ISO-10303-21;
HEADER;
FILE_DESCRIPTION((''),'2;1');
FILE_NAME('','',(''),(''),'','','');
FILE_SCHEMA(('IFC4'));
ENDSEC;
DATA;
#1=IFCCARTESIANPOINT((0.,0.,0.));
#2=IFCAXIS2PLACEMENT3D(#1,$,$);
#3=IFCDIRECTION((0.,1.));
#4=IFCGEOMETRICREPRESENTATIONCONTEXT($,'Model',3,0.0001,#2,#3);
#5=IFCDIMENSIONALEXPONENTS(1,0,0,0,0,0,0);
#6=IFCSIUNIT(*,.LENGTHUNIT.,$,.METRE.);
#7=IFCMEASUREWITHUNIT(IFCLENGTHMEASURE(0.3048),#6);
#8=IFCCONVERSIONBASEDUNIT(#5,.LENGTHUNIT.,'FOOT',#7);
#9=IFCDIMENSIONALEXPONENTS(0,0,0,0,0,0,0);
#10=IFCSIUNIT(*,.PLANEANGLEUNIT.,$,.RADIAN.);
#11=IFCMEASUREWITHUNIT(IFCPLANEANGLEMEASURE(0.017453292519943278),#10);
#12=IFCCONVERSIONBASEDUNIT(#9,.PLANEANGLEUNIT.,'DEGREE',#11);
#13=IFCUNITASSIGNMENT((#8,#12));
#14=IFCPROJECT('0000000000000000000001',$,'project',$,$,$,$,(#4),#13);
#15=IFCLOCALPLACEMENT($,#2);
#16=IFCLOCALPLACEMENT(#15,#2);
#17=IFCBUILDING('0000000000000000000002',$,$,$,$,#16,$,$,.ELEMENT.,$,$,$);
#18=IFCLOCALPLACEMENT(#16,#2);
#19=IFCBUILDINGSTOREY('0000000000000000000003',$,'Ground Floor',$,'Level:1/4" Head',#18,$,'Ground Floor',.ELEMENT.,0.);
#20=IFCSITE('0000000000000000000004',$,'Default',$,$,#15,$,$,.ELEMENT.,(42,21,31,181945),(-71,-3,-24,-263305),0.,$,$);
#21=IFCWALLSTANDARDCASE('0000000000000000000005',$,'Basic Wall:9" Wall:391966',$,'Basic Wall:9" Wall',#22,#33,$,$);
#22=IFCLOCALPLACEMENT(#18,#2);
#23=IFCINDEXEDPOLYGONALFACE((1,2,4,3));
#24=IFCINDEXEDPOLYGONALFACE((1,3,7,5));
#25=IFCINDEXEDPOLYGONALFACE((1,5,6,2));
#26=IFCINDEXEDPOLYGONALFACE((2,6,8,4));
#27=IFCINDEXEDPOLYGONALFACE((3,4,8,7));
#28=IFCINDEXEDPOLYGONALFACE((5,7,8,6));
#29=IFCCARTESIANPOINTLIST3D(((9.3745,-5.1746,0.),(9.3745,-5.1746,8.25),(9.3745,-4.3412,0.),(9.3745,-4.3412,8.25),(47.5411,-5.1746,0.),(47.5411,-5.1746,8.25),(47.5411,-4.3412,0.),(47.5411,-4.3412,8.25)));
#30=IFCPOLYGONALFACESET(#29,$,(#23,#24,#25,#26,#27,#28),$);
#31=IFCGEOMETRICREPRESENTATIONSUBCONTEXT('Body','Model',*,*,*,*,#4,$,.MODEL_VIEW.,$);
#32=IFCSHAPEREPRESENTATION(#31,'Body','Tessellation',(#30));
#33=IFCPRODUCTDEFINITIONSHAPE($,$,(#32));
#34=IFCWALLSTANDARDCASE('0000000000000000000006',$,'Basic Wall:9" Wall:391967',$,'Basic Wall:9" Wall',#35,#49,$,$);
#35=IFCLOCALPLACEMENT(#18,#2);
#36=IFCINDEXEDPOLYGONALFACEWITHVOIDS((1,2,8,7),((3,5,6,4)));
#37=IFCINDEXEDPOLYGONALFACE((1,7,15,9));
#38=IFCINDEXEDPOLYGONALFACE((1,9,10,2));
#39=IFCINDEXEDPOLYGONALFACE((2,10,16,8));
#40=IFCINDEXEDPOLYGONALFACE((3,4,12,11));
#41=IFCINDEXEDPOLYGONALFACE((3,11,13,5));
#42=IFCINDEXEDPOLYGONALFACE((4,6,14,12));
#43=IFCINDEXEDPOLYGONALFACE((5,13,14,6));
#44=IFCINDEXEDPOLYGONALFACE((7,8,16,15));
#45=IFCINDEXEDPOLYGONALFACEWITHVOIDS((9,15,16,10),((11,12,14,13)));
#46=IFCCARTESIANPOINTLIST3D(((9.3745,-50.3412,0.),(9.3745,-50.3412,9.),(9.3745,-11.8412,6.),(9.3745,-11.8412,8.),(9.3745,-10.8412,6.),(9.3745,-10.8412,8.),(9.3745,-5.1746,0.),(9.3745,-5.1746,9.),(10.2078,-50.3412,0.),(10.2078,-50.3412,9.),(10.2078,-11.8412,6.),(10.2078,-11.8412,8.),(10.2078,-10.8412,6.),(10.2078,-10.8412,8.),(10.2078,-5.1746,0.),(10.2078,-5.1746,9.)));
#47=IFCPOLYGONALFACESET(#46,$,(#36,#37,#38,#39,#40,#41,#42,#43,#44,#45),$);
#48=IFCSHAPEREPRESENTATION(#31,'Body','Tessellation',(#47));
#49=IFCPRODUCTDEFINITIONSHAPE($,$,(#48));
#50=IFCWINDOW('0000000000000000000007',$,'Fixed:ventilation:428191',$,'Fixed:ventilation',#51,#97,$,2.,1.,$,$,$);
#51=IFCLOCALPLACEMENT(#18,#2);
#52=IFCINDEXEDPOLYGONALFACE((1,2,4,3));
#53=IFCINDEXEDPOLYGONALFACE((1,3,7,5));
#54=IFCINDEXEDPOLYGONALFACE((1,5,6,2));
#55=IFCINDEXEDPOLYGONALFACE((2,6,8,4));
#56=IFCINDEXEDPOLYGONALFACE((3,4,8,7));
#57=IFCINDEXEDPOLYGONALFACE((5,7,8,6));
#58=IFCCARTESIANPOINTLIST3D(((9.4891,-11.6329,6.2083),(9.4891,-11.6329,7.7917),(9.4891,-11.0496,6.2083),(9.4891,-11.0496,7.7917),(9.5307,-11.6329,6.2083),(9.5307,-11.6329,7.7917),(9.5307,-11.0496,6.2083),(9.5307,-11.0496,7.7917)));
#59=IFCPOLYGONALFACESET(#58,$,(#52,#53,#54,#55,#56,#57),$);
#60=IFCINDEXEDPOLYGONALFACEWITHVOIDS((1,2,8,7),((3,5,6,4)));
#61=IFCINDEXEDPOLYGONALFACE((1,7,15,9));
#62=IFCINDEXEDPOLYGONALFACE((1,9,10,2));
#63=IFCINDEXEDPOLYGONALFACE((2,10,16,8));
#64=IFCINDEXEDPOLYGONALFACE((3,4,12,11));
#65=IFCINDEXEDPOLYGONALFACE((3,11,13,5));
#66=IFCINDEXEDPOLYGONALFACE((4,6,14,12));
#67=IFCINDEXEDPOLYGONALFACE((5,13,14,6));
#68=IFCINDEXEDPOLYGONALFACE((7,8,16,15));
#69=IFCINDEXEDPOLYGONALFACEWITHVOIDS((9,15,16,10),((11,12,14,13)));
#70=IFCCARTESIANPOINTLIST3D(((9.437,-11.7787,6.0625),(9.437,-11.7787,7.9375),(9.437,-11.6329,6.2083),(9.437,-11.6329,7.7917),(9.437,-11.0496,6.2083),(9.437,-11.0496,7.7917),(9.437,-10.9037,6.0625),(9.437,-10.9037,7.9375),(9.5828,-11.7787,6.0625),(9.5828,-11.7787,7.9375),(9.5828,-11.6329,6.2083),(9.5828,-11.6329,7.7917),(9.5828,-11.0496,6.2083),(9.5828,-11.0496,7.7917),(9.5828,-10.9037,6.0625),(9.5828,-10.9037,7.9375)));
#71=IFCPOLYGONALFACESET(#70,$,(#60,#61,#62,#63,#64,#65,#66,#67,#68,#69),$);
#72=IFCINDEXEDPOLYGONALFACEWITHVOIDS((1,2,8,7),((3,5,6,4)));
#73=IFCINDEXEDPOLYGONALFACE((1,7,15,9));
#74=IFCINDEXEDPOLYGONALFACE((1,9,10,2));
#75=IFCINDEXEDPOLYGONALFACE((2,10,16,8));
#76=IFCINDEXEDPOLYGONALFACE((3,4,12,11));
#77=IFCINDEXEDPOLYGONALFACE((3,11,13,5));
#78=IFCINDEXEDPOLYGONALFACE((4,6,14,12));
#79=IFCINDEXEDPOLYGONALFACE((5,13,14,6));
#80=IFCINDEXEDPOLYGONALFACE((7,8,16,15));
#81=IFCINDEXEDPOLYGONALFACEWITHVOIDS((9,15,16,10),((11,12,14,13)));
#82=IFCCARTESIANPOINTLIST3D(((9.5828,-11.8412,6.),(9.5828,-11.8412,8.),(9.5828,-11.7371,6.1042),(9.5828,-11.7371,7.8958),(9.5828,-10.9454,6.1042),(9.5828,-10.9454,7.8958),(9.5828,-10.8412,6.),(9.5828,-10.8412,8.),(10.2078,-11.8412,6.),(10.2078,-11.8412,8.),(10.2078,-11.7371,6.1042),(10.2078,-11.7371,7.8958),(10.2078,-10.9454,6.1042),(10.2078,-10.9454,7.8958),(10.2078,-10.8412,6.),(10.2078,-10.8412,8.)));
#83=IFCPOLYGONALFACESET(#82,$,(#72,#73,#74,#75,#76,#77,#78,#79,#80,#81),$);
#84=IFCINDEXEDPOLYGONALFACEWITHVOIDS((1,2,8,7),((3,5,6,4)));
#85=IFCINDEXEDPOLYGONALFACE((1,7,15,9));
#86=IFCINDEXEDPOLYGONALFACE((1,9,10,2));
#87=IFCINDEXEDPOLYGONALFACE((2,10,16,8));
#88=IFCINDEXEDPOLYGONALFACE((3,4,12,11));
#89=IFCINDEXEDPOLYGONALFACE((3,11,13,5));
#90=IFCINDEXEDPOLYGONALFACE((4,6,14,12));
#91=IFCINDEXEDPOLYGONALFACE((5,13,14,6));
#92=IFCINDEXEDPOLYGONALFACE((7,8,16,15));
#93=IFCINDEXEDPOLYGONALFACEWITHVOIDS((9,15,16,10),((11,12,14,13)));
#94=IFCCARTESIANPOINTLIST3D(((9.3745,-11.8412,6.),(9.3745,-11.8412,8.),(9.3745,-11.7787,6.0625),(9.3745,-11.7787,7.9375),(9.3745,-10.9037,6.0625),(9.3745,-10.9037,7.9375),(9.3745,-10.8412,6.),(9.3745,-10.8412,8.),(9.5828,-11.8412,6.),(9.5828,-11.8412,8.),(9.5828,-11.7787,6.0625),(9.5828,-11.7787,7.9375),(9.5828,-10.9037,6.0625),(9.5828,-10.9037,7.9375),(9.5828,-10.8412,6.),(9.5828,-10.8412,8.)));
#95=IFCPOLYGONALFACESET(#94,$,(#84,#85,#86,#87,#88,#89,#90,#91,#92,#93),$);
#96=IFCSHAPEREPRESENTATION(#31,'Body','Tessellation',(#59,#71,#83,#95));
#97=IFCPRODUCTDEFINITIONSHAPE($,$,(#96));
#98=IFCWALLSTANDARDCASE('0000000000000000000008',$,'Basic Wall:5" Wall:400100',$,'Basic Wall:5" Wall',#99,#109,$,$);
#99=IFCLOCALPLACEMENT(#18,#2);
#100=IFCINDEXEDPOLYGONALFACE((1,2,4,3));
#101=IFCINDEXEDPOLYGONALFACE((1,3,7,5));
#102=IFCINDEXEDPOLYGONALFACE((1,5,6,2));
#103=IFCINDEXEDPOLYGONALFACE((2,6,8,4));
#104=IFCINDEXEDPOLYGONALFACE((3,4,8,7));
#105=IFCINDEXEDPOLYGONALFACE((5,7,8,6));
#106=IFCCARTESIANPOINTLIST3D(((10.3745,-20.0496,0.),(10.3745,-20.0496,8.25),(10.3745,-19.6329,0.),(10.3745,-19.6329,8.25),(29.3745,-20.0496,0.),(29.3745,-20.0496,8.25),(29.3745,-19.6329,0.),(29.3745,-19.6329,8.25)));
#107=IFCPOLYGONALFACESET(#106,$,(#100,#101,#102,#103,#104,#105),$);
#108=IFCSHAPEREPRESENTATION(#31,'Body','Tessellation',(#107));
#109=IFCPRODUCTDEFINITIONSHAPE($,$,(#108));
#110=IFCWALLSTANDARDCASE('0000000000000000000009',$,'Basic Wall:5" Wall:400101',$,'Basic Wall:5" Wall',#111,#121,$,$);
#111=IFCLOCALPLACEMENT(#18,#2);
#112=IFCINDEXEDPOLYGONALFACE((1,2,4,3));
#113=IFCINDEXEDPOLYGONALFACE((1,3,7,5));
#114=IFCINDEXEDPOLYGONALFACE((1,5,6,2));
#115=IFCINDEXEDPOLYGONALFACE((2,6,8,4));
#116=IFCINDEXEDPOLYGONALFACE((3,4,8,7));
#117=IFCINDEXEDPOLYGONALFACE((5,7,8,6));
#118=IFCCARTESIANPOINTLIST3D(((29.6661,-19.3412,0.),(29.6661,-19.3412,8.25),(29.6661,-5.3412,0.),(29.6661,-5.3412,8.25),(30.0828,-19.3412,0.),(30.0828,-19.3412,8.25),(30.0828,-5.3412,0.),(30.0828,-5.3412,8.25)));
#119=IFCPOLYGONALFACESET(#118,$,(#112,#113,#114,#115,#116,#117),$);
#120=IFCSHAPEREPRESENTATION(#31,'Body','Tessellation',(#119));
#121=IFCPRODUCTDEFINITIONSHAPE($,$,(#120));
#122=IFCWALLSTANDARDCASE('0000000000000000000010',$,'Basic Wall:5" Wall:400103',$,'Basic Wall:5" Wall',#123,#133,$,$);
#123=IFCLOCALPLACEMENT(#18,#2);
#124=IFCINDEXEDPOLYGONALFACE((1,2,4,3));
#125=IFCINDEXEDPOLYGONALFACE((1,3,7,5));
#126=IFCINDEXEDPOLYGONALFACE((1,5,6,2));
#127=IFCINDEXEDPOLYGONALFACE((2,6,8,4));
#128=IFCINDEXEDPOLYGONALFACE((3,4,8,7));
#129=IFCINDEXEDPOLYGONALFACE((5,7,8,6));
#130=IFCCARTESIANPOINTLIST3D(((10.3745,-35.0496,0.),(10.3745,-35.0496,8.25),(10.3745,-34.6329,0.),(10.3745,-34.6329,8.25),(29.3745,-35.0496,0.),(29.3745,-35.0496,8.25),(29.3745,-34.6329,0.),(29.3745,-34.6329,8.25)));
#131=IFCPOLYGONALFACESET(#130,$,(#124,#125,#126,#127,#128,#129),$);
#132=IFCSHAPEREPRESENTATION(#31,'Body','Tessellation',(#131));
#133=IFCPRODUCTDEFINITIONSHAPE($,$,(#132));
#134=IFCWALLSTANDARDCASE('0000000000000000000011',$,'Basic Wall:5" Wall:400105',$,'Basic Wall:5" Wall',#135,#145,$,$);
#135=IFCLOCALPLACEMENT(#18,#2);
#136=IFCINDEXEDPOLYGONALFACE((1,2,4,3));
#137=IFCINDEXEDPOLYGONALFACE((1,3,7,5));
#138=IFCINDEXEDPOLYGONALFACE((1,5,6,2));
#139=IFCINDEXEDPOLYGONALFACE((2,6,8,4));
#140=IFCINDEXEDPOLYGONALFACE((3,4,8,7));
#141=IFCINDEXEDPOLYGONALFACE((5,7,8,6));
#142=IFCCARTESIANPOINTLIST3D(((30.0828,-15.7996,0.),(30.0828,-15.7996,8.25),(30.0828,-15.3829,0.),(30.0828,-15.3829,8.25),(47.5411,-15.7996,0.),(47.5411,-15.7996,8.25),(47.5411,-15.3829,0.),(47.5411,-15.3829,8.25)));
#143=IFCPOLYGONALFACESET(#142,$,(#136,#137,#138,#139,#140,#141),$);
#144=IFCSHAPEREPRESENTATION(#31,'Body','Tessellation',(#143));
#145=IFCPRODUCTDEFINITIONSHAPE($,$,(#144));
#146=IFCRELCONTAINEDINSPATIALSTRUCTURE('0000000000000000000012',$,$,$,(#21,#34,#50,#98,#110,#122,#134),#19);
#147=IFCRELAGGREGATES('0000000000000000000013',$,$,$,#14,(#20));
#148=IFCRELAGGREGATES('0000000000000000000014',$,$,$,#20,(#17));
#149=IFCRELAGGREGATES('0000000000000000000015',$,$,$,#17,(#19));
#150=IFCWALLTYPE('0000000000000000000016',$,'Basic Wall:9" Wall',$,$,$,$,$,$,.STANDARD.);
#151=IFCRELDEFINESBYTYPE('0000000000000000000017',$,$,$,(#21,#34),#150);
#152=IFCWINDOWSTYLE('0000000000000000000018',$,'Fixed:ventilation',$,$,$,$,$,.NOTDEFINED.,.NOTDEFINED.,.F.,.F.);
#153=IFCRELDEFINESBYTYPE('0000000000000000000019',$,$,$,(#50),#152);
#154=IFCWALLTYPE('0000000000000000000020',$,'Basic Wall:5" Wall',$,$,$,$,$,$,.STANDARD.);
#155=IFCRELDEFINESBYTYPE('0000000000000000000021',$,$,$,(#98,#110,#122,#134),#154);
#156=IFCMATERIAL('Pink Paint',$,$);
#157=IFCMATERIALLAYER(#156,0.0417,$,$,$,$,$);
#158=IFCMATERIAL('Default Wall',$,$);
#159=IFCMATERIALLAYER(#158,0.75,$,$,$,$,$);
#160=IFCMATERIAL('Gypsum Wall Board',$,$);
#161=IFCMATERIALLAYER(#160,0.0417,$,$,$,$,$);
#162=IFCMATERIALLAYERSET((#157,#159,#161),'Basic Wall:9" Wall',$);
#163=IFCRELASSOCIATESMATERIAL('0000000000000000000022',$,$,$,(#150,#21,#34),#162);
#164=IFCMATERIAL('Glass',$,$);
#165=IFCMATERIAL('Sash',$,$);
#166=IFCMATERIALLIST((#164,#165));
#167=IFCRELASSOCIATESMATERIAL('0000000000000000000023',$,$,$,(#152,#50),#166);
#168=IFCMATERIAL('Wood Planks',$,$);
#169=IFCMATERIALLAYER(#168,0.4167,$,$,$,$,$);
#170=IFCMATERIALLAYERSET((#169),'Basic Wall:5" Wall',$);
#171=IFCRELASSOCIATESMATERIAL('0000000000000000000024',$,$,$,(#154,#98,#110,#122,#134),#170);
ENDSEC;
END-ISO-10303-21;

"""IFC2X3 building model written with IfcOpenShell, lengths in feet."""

from ifc_helpers import new_model, entity, si_unit, converted_unit, direction, frame, frame_2d, origin, origin_2d_with_axis, place, context, subcontext, project, spatial, polyline, rectangle, outline, extrude, clip, bounded_halfspace, source, transform, mapped, material, material_list, layer, layer_set, layer_usage, type_object, type_shapes, element, fill, save


model = new_model("IFC2X3")

# Units and contexts
model_context = context("Model", 3, precision=0.0001, world=origin(), true_north=direction((0.0, 1.0)))
body_context = subcontext(model_context, "Body", "Model", "MODEL_VIEW")
ifc_project = project(units=[converted_unit("LENGTHUNIT", "FOOT", entity("IfcLengthMeasure", 0.3048), si_unit("LENGTHUNIT", "METRE"), dimensions=[1, 0, 0, 0, 0, 0, 0]), converted_unit("PLANEANGLEUNIT", "DEGREE", entity("IfcPlaneAngleMeasure", 0.017453292519943278), si_unit("PLANEANGLEUNIT", "RADIAN"), dimensions=[0, 0, 0, 0, 0, 0, 0])], contexts=[model_context])

# Site, building, storey
site_placement = place(None, origin())
site = spatial("IfcSite", under=ifc_project, at=site_placement, Name="Default", CompositionType="ELEMENT", RefLatitude=(42, 21, 31, 181945), RefLongitude=(-71, -3, -24, -263305), RefElevation=0.0)
building_placement = place(site_placement, origin())
building = spatial("IfcBuilding", under=site, at=building_placement, CompositionType="ELEMENT")
storey_placement = place(building_placement, origin())
storey = spatial("IfcBuildingStorey", under=building, at=storey_placement, Name="Ground Floor", ObjectType="Level:1/4\" Head", LongName="Ground Floor", CompositionType="ELEMENT", Elevation=0.0)

# Wall
ifc_material_1 = material(Name="Pink Paint")
ifc_layer_1 = layer(ifc_material_1, 0.0417)
ifc_material_2 = material(Name="Default Wall")
ifc_layer_2 = layer(ifc_material_2, 0.75)
ifc_material_3 = material(Name="Gypsum Wall Board")
ifc_layer_3 = layer(ifc_material_3, 0.0417)
ifc_layer_set_1 = layer_set([ifc_layer_1, ifc_layer_2, ifc_layer_3], Name="Basic Wall:9\" Wall")
ifc_layer_usage_1 = layer_usage(ifc_layer_set_1, "AXIS2", "NEGATIVE", 0.4167)
wall_type_1 = type_object("IfcWallType", Name="Basic Wall:9\" Wall", PredefinedType="STANDARD", material=ifc_layer_set_1)
wall_1_placement = place(storey_placement, frame((9.3745, -4.7579, 0.0)))
element("IfcWallStandardCase", 1, at=wall_1_placement, inside=storey, type_object=wall_type_1, material=ifc_layer_usage_1, Name="Basic Wall:9\" Wall:391966", ObjectType="Basic Wall:9\" Wall", context=body_context, shape_type="SweptSolid", body=[
    extrude(rectangle(XDim=38.1667, YDim=0.8333, at=frame_2d((19.0833, 0.0), x_axis=(-1.0, 0.0))), origin(), (0.0, 0.0, 1.0), 8.25),
])

# Wall, opening, window
wall_2_placement = place(storey_placement, frame((9.7911, -50.3412, 0.0), z_axis=(0.0, 0.0, 1.0), x_axis=(0.0, 1.0, 0.0)))
wall_2 = element("IfcWallStandardCase", 2, at=wall_2_placement, inside=storey, type_object=wall_type_1, material=ifc_layer_usage_1, Name="Basic Wall:9\" Wall:391967", ObjectType="Basic Wall:9\" Wall", context=body_context, shape_type="Clipping", body=[
    clip(extrude(rectangle(XDim=45.1667, YDim=0.8333, at=frame_2d((22.5833, 0.0), x_axis=(-1.0, 0.0))), origin(), (0.0, 0.0, 1.0), 9.0), bounded_halfspace(frame((0.0, -0.4167, 9.0), z_axis=(0.0, 0.0, -1.0), x_axis=(-1.0, 0.0, 0.0)), True, frame((0.0, -0.4167, 9.0)), polyline([(0.0, 0.0), (0.8333, 0.0), (45.1667, 0.0), (45.1667, 0.8333), (0.0, 0.8333), (0.0, 0.0)]))),
])
opening_1_placement = place(wall_2_placement, frame((38.5, -0.4167, 6.0)))
opening_1 = element("IfcOpeningElement", 3, at=opening_1_placement, cuts=wall_2, ObjectType="Opening", context=body_context, shape_type="SweptSolid", body=[
    extrude(rectangle(XDim=2.0, YDim=1.0, at=frame_2d((1.0, 0.5), x_axis=(-1.0, 0.0))), frame((0.0, 0.0, 0.0), z_axis=(0.0, 1.0, 0.0), x_axis=(0.0, 0.0, 1.0)), (0.0, 0.0, 1.0), 0.8333),
])
ifc_material_4 = material(Name="Glass")
ifc_material_5 = material(Name="Sash")
ifc_material_list_1 = material_list([ifc_material_4, ifc_material_5])
window_style = type_object("IfcWindowStyle", Name="Fixed:ventilation", ConstructionType="NOTDEFINED", OperationType="NOTDEFINED", ParameterTakesPrecedence=False, Sizeable=False, material=ifc_material_list_1)
shared_shape_1 = source(origin(), body_context, "Body", "SweptSolid", [
    extrude(rectangle(XDim=0.0417, YDim=0.5833, at=origin_2d_with_axis()), frame((0.5, 0.6979, 0.2083), z_axis=(0.0, 0.0, 1.0), x_axis=(0.0, 1.0, 0.0)), (0.0, 0.0, 1.0), 1.5833),
    extrude(outline(polyline([(-0.4375, -0.9375), (0.4375, -0.9375), (0.4375, 0.9375), (-0.4375, 0.9375), (-0.4375, -0.9375)]), holes=[polyline([(-0.2917, -0.7917), (-0.2917, 0.7917), (0.2917, 0.7917), (0.2917, -0.7917), (-0.2917, -0.7917)])]), frame((0.5, 0.625, 1.0), z_axis=(0.0, 1.0, 0.0), x_axis=(1.0, 0.0, 0.0)), (0.0, 0.0, 1.0), 0.1458),
    extrude(outline(polyline([(-0.5, -1.0), (0.5, -1.0), (0.5, 1.0), (-0.5, 1.0), (-0.5, -1.0)]), holes=[polyline([(-0.3958, -0.8958), (-0.3958, 0.8958), (0.3958, 0.8958), (0.3958, -0.8958), (-0.3958, -0.8958)])]), frame((0.5, 0.0, 1.0), z_axis=(0.0, 1.0, 0.0), x_axis=(1.0, 0.0, 0.0)), (0.0, 0.0, 1.0), 0.625),
    extrude(outline(polyline([(-1.0, -0.5), (1.0, -0.5), (1.0, 0.5), (-1.0, 0.5), (-1.0, -0.5)]), holes=[polyline([(-0.9375, -0.4375), (-0.9375, 0.4375), (0.9375, 0.4375), (0.9375, -0.4375), (-0.9375, -0.4375)])]), frame((0.5, 0.625, 1.0), z_axis=(0.0, 1.0, 0.0), x_axis=(0.0, 0.0, -1.0)), (0.0, 0.0, 1.0), 0.2083),
])
type_shapes(window_style, [shared_shape_1])
window_placement = place(opening_1_placement, origin())
window = element("IfcWindow", 4, at=window_placement, inside=storey, type_object=window_style, material=ifc_material_list_1, Name="Fixed:ventilation:428191", ObjectType="Fixed:ventilation", OverallHeight=2.0, OverallWidth=1.0, context=body_context, shape_type="MappedRepresentation", body=[
    mapped(shared_shape_1, transform((0.0, 0.0, 0.0), scale=1.0)),
])
fill(opening_1, window)

# Walls
ifc_material_6 = material(Name="Wood Planks")
ifc_layer_4 = layer(ifc_material_6, 0.4167)
ifc_layer_set_2 = layer_set([ifc_layer_4], Name="Basic Wall:5\" Wall")
ifc_layer_usage_2 = layer_usage(ifc_layer_set_2, "AXIS2", "NEGATIVE", 0.2083)
wall_type_2 = type_object("IfcWallType", Name="Basic Wall:5\" Wall", PredefinedType="STANDARD", material=ifc_layer_set_2)
wall_3_placement = place(storey_placement, frame((10.3745, -19.8412, 0.0)))
element("IfcWallStandardCase", 5, at=wall_3_placement, inside=storey, type_object=wall_type_2, material=ifc_layer_usage_2, Name="Basic Wall:5\" Wall:400100", ObjectType="Basic Wall:5\" Wall", context=body_context, shape_type="SweptSolid", body=[
    extrude(rectangle(XDim=19.0, YDim=0.4167, at=frame_2d((9.5, 0.0), x_axis=(-1.0, 0.0))), origin(), (0.0, 0.0, 1.0), 8.25),
])
wall_4_placement = place(storey_placement, frame((29.8745, -19.3412, 0.0), z_axis=(0.0, 0.0, 1.0), x_axis=(0.0, 1.0, 0.0)))
element("IfcWallStandardCase", 6, at=wall_4_placement, inside=storey, type_object=wall_type_2, material=ifc_layer_usage_2, Name="Basic Wall:5\" Wall:400101", ObjectType="Basic Wall:5\" Wall", context=body_context, shape_type="SweptSolid", body=[
    extrude(rectangle(XDim=14.0, YDim=0.4167, at=frame_2d((7.0, 0.0), x_axis=(-1.0, 0.0))), origin(), (0.0, 0.0, 1.0), 8.25),
])

# Wall
wall_5_placement = place(storey_placement, frame((29.3745, -34.8412, 0.0), z_axis=(0.0, 0.0, 1.0), x_axis=(-1.0, 0.0, 0.0)))
element("IfcWallStandardCase", 7, at=wall_5_placement, inside=storey, type_object=wall_type_2, material=ifc_layer_usage_2, Name="Basic Wall:5\" Wall:400103", ObjectType="Basic Wall:5\" Wall", context=body_context, shape_type="SweptSolid", body=[
    extrude(rectangle(XDim=19.0, YDim=0.4167, at=frame_2d((9.5, 0.0), x_axis=(-1.0, 0.0))), origin(), (0.0, 0.0, 1.0), 8.25),
])

# Wall
wall_6_placement = place(storey_placement, frame((30.0828, -15.5912, 0.0)))
element("IfcWallStandardCase", 8, at=wall_6_placement, inside=storey, type_object=wall_type_2, material=ifc_layer_usage_2, Name="Basic Wall:5\" Wall:400105", ObjectType="Basic Wall:5\" Wall", context=body_context, shape_type="SweptSolid", body=[
    extrude(rectangle(XDim=17.4583, YDim=0.4167, at=frame_2d((8.7292, 0.0), x_axis=(-1.0, 0.0))), origin(), (0.0, 0.0, 1.0), 8.25),
])

save(model, "model.ifc")
